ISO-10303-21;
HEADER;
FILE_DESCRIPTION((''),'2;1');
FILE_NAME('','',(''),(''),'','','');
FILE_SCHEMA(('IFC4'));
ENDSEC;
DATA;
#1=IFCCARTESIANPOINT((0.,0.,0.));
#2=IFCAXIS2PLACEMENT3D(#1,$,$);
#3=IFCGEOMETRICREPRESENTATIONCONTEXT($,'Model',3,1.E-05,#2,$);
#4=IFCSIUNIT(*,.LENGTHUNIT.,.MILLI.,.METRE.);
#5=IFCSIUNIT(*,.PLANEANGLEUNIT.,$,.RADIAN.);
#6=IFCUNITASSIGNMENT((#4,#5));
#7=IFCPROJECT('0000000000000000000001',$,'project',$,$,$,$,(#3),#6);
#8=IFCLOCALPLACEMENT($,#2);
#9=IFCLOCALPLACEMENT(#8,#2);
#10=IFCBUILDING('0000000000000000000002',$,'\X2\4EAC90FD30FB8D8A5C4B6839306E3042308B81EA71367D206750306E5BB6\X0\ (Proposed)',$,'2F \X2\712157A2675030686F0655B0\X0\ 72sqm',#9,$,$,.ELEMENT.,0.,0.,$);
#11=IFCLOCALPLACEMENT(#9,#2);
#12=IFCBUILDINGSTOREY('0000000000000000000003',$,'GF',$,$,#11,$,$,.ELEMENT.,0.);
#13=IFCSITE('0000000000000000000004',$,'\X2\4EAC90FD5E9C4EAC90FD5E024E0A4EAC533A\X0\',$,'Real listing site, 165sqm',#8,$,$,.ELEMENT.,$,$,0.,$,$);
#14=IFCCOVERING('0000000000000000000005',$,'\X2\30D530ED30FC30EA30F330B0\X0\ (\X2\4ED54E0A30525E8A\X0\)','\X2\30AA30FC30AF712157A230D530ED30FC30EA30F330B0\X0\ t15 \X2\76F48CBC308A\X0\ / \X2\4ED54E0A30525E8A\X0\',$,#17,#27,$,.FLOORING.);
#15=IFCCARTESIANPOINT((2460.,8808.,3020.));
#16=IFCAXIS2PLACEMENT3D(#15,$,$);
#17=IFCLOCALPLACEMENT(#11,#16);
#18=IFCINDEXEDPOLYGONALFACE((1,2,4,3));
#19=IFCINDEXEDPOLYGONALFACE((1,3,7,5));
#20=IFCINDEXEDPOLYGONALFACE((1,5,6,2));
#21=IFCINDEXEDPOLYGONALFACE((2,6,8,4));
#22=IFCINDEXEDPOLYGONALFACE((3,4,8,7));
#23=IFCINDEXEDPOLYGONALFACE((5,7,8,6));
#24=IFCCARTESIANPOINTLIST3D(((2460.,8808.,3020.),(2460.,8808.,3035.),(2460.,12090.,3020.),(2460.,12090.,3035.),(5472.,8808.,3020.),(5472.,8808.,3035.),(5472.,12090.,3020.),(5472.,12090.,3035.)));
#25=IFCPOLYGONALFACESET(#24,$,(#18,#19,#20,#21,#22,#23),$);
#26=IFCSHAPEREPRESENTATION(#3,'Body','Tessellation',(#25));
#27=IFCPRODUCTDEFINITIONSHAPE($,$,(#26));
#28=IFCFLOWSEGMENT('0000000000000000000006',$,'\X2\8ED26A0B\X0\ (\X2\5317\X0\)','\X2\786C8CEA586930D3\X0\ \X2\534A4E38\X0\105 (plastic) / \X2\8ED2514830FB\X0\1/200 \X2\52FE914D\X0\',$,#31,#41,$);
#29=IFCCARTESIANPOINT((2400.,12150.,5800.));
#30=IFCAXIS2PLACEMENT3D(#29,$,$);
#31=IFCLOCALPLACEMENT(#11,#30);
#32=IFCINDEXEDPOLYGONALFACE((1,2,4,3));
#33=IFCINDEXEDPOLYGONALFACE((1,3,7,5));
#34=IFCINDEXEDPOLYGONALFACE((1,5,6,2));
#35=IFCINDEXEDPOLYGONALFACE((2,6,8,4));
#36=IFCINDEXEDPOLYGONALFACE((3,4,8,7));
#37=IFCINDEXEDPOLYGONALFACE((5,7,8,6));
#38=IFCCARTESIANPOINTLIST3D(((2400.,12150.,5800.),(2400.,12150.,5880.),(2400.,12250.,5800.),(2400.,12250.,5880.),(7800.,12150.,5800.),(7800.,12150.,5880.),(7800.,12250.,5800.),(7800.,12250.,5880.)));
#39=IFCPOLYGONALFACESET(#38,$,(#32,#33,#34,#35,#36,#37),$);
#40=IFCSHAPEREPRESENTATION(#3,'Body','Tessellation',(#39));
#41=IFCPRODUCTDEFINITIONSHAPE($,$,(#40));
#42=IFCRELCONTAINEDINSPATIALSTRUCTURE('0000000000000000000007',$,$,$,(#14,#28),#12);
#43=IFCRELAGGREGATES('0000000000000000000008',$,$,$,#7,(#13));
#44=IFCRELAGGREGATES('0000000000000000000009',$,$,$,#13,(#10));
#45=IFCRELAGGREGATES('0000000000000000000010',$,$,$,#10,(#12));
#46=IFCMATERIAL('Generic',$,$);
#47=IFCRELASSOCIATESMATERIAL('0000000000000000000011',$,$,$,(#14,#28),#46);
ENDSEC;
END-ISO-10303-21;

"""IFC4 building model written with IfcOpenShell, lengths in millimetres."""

from ifc_helpers import new_model, si_unit, frame, frame_2d, origin, place, context, project, spatial, rectangle, extrude, material, element, save


model = new_model("IFC4")

# Units and contexts
model_context = context("Model", 3, precision=1e-05, world=origin())
ifc_project = project(units=[si_unit("LENGTHUNIT", "METRE", prefix="MILLI"), si_unit("PLANEANGLEUNIT", "RADIAN")], contexts=[model_context])

# Site, building, storey
site_placement = place(None, origin())
site = spatial("IfcSite", under=ifc_project, at=site_placement, Name="京都府京都市上京区", ObjectType="Real listing site, 165sqm", CompositionType="ELEMENT", RefElevation=0.0)
building_placement = place(site_placement, origin())
building = spatial("IfcBuilding", under=site, at=building_placement, Name="京都・越屋根のある自然素材の家 (Proposed)", ObjectType="2F 無垢材と漆喰 72sqm", CompositionType="ELEMENT", ElevationOfRefHeight=0.0, ElevationOfTerrain=0.0)
storey_placement = place(building_placement, origin())
storey = spatial("IfcBuildingStorey", under=building, at=storey_placement, Name="GF", CompositionType="ELEMENT", Elevation=0.0)

# Covering
ifc_material_1 = material(Name="Generic")
covering_placement = place(storey_placement, frame((2460.0, 8808.0, 3020.0)))
element("IfcCovering", 1, at=covering_placement, inside=storey, material=ifc_material_1, Name="フローリング (仕上げ床)", Description="オーク無垢フローリング t15 直貼り / 仕上げ床", PredefinedType="FLOORING", context=model_context, shape_type="SweptSolid", body=[
    extrude(rectangle(XDim=3012.0, YDim=3282.0, at=frame_2d((1506.0, 1641.0))), frame((2460.0, 8808.0, 3020.0)), (0.0, 0.0, 1.0), 15.0),
])

# Flow segment
flow_segment_placement = place(storey_placement, frame((2400.0, 12150.0, 5800.0)))
element("IfcFlowSegment", 2, at=flow_segment_placement, inside=storey, material=ifc_material_1, Name="軒樋 (北)", Description="硬質塩ビ 半丸105 (plastic) / 軒先・1/200 勾配", context=model_context, shape_type="SweptSolid", body=[
    extrude(rectangle(XDim=5400.0, YDim=100.0, at=frame_2d((2700.0, 50.0))), frame((2400.0, 12150.0, 5800.0)), (0.0, 0.0, 1.0), 80.0),
])

save(model, "model.ifc")
